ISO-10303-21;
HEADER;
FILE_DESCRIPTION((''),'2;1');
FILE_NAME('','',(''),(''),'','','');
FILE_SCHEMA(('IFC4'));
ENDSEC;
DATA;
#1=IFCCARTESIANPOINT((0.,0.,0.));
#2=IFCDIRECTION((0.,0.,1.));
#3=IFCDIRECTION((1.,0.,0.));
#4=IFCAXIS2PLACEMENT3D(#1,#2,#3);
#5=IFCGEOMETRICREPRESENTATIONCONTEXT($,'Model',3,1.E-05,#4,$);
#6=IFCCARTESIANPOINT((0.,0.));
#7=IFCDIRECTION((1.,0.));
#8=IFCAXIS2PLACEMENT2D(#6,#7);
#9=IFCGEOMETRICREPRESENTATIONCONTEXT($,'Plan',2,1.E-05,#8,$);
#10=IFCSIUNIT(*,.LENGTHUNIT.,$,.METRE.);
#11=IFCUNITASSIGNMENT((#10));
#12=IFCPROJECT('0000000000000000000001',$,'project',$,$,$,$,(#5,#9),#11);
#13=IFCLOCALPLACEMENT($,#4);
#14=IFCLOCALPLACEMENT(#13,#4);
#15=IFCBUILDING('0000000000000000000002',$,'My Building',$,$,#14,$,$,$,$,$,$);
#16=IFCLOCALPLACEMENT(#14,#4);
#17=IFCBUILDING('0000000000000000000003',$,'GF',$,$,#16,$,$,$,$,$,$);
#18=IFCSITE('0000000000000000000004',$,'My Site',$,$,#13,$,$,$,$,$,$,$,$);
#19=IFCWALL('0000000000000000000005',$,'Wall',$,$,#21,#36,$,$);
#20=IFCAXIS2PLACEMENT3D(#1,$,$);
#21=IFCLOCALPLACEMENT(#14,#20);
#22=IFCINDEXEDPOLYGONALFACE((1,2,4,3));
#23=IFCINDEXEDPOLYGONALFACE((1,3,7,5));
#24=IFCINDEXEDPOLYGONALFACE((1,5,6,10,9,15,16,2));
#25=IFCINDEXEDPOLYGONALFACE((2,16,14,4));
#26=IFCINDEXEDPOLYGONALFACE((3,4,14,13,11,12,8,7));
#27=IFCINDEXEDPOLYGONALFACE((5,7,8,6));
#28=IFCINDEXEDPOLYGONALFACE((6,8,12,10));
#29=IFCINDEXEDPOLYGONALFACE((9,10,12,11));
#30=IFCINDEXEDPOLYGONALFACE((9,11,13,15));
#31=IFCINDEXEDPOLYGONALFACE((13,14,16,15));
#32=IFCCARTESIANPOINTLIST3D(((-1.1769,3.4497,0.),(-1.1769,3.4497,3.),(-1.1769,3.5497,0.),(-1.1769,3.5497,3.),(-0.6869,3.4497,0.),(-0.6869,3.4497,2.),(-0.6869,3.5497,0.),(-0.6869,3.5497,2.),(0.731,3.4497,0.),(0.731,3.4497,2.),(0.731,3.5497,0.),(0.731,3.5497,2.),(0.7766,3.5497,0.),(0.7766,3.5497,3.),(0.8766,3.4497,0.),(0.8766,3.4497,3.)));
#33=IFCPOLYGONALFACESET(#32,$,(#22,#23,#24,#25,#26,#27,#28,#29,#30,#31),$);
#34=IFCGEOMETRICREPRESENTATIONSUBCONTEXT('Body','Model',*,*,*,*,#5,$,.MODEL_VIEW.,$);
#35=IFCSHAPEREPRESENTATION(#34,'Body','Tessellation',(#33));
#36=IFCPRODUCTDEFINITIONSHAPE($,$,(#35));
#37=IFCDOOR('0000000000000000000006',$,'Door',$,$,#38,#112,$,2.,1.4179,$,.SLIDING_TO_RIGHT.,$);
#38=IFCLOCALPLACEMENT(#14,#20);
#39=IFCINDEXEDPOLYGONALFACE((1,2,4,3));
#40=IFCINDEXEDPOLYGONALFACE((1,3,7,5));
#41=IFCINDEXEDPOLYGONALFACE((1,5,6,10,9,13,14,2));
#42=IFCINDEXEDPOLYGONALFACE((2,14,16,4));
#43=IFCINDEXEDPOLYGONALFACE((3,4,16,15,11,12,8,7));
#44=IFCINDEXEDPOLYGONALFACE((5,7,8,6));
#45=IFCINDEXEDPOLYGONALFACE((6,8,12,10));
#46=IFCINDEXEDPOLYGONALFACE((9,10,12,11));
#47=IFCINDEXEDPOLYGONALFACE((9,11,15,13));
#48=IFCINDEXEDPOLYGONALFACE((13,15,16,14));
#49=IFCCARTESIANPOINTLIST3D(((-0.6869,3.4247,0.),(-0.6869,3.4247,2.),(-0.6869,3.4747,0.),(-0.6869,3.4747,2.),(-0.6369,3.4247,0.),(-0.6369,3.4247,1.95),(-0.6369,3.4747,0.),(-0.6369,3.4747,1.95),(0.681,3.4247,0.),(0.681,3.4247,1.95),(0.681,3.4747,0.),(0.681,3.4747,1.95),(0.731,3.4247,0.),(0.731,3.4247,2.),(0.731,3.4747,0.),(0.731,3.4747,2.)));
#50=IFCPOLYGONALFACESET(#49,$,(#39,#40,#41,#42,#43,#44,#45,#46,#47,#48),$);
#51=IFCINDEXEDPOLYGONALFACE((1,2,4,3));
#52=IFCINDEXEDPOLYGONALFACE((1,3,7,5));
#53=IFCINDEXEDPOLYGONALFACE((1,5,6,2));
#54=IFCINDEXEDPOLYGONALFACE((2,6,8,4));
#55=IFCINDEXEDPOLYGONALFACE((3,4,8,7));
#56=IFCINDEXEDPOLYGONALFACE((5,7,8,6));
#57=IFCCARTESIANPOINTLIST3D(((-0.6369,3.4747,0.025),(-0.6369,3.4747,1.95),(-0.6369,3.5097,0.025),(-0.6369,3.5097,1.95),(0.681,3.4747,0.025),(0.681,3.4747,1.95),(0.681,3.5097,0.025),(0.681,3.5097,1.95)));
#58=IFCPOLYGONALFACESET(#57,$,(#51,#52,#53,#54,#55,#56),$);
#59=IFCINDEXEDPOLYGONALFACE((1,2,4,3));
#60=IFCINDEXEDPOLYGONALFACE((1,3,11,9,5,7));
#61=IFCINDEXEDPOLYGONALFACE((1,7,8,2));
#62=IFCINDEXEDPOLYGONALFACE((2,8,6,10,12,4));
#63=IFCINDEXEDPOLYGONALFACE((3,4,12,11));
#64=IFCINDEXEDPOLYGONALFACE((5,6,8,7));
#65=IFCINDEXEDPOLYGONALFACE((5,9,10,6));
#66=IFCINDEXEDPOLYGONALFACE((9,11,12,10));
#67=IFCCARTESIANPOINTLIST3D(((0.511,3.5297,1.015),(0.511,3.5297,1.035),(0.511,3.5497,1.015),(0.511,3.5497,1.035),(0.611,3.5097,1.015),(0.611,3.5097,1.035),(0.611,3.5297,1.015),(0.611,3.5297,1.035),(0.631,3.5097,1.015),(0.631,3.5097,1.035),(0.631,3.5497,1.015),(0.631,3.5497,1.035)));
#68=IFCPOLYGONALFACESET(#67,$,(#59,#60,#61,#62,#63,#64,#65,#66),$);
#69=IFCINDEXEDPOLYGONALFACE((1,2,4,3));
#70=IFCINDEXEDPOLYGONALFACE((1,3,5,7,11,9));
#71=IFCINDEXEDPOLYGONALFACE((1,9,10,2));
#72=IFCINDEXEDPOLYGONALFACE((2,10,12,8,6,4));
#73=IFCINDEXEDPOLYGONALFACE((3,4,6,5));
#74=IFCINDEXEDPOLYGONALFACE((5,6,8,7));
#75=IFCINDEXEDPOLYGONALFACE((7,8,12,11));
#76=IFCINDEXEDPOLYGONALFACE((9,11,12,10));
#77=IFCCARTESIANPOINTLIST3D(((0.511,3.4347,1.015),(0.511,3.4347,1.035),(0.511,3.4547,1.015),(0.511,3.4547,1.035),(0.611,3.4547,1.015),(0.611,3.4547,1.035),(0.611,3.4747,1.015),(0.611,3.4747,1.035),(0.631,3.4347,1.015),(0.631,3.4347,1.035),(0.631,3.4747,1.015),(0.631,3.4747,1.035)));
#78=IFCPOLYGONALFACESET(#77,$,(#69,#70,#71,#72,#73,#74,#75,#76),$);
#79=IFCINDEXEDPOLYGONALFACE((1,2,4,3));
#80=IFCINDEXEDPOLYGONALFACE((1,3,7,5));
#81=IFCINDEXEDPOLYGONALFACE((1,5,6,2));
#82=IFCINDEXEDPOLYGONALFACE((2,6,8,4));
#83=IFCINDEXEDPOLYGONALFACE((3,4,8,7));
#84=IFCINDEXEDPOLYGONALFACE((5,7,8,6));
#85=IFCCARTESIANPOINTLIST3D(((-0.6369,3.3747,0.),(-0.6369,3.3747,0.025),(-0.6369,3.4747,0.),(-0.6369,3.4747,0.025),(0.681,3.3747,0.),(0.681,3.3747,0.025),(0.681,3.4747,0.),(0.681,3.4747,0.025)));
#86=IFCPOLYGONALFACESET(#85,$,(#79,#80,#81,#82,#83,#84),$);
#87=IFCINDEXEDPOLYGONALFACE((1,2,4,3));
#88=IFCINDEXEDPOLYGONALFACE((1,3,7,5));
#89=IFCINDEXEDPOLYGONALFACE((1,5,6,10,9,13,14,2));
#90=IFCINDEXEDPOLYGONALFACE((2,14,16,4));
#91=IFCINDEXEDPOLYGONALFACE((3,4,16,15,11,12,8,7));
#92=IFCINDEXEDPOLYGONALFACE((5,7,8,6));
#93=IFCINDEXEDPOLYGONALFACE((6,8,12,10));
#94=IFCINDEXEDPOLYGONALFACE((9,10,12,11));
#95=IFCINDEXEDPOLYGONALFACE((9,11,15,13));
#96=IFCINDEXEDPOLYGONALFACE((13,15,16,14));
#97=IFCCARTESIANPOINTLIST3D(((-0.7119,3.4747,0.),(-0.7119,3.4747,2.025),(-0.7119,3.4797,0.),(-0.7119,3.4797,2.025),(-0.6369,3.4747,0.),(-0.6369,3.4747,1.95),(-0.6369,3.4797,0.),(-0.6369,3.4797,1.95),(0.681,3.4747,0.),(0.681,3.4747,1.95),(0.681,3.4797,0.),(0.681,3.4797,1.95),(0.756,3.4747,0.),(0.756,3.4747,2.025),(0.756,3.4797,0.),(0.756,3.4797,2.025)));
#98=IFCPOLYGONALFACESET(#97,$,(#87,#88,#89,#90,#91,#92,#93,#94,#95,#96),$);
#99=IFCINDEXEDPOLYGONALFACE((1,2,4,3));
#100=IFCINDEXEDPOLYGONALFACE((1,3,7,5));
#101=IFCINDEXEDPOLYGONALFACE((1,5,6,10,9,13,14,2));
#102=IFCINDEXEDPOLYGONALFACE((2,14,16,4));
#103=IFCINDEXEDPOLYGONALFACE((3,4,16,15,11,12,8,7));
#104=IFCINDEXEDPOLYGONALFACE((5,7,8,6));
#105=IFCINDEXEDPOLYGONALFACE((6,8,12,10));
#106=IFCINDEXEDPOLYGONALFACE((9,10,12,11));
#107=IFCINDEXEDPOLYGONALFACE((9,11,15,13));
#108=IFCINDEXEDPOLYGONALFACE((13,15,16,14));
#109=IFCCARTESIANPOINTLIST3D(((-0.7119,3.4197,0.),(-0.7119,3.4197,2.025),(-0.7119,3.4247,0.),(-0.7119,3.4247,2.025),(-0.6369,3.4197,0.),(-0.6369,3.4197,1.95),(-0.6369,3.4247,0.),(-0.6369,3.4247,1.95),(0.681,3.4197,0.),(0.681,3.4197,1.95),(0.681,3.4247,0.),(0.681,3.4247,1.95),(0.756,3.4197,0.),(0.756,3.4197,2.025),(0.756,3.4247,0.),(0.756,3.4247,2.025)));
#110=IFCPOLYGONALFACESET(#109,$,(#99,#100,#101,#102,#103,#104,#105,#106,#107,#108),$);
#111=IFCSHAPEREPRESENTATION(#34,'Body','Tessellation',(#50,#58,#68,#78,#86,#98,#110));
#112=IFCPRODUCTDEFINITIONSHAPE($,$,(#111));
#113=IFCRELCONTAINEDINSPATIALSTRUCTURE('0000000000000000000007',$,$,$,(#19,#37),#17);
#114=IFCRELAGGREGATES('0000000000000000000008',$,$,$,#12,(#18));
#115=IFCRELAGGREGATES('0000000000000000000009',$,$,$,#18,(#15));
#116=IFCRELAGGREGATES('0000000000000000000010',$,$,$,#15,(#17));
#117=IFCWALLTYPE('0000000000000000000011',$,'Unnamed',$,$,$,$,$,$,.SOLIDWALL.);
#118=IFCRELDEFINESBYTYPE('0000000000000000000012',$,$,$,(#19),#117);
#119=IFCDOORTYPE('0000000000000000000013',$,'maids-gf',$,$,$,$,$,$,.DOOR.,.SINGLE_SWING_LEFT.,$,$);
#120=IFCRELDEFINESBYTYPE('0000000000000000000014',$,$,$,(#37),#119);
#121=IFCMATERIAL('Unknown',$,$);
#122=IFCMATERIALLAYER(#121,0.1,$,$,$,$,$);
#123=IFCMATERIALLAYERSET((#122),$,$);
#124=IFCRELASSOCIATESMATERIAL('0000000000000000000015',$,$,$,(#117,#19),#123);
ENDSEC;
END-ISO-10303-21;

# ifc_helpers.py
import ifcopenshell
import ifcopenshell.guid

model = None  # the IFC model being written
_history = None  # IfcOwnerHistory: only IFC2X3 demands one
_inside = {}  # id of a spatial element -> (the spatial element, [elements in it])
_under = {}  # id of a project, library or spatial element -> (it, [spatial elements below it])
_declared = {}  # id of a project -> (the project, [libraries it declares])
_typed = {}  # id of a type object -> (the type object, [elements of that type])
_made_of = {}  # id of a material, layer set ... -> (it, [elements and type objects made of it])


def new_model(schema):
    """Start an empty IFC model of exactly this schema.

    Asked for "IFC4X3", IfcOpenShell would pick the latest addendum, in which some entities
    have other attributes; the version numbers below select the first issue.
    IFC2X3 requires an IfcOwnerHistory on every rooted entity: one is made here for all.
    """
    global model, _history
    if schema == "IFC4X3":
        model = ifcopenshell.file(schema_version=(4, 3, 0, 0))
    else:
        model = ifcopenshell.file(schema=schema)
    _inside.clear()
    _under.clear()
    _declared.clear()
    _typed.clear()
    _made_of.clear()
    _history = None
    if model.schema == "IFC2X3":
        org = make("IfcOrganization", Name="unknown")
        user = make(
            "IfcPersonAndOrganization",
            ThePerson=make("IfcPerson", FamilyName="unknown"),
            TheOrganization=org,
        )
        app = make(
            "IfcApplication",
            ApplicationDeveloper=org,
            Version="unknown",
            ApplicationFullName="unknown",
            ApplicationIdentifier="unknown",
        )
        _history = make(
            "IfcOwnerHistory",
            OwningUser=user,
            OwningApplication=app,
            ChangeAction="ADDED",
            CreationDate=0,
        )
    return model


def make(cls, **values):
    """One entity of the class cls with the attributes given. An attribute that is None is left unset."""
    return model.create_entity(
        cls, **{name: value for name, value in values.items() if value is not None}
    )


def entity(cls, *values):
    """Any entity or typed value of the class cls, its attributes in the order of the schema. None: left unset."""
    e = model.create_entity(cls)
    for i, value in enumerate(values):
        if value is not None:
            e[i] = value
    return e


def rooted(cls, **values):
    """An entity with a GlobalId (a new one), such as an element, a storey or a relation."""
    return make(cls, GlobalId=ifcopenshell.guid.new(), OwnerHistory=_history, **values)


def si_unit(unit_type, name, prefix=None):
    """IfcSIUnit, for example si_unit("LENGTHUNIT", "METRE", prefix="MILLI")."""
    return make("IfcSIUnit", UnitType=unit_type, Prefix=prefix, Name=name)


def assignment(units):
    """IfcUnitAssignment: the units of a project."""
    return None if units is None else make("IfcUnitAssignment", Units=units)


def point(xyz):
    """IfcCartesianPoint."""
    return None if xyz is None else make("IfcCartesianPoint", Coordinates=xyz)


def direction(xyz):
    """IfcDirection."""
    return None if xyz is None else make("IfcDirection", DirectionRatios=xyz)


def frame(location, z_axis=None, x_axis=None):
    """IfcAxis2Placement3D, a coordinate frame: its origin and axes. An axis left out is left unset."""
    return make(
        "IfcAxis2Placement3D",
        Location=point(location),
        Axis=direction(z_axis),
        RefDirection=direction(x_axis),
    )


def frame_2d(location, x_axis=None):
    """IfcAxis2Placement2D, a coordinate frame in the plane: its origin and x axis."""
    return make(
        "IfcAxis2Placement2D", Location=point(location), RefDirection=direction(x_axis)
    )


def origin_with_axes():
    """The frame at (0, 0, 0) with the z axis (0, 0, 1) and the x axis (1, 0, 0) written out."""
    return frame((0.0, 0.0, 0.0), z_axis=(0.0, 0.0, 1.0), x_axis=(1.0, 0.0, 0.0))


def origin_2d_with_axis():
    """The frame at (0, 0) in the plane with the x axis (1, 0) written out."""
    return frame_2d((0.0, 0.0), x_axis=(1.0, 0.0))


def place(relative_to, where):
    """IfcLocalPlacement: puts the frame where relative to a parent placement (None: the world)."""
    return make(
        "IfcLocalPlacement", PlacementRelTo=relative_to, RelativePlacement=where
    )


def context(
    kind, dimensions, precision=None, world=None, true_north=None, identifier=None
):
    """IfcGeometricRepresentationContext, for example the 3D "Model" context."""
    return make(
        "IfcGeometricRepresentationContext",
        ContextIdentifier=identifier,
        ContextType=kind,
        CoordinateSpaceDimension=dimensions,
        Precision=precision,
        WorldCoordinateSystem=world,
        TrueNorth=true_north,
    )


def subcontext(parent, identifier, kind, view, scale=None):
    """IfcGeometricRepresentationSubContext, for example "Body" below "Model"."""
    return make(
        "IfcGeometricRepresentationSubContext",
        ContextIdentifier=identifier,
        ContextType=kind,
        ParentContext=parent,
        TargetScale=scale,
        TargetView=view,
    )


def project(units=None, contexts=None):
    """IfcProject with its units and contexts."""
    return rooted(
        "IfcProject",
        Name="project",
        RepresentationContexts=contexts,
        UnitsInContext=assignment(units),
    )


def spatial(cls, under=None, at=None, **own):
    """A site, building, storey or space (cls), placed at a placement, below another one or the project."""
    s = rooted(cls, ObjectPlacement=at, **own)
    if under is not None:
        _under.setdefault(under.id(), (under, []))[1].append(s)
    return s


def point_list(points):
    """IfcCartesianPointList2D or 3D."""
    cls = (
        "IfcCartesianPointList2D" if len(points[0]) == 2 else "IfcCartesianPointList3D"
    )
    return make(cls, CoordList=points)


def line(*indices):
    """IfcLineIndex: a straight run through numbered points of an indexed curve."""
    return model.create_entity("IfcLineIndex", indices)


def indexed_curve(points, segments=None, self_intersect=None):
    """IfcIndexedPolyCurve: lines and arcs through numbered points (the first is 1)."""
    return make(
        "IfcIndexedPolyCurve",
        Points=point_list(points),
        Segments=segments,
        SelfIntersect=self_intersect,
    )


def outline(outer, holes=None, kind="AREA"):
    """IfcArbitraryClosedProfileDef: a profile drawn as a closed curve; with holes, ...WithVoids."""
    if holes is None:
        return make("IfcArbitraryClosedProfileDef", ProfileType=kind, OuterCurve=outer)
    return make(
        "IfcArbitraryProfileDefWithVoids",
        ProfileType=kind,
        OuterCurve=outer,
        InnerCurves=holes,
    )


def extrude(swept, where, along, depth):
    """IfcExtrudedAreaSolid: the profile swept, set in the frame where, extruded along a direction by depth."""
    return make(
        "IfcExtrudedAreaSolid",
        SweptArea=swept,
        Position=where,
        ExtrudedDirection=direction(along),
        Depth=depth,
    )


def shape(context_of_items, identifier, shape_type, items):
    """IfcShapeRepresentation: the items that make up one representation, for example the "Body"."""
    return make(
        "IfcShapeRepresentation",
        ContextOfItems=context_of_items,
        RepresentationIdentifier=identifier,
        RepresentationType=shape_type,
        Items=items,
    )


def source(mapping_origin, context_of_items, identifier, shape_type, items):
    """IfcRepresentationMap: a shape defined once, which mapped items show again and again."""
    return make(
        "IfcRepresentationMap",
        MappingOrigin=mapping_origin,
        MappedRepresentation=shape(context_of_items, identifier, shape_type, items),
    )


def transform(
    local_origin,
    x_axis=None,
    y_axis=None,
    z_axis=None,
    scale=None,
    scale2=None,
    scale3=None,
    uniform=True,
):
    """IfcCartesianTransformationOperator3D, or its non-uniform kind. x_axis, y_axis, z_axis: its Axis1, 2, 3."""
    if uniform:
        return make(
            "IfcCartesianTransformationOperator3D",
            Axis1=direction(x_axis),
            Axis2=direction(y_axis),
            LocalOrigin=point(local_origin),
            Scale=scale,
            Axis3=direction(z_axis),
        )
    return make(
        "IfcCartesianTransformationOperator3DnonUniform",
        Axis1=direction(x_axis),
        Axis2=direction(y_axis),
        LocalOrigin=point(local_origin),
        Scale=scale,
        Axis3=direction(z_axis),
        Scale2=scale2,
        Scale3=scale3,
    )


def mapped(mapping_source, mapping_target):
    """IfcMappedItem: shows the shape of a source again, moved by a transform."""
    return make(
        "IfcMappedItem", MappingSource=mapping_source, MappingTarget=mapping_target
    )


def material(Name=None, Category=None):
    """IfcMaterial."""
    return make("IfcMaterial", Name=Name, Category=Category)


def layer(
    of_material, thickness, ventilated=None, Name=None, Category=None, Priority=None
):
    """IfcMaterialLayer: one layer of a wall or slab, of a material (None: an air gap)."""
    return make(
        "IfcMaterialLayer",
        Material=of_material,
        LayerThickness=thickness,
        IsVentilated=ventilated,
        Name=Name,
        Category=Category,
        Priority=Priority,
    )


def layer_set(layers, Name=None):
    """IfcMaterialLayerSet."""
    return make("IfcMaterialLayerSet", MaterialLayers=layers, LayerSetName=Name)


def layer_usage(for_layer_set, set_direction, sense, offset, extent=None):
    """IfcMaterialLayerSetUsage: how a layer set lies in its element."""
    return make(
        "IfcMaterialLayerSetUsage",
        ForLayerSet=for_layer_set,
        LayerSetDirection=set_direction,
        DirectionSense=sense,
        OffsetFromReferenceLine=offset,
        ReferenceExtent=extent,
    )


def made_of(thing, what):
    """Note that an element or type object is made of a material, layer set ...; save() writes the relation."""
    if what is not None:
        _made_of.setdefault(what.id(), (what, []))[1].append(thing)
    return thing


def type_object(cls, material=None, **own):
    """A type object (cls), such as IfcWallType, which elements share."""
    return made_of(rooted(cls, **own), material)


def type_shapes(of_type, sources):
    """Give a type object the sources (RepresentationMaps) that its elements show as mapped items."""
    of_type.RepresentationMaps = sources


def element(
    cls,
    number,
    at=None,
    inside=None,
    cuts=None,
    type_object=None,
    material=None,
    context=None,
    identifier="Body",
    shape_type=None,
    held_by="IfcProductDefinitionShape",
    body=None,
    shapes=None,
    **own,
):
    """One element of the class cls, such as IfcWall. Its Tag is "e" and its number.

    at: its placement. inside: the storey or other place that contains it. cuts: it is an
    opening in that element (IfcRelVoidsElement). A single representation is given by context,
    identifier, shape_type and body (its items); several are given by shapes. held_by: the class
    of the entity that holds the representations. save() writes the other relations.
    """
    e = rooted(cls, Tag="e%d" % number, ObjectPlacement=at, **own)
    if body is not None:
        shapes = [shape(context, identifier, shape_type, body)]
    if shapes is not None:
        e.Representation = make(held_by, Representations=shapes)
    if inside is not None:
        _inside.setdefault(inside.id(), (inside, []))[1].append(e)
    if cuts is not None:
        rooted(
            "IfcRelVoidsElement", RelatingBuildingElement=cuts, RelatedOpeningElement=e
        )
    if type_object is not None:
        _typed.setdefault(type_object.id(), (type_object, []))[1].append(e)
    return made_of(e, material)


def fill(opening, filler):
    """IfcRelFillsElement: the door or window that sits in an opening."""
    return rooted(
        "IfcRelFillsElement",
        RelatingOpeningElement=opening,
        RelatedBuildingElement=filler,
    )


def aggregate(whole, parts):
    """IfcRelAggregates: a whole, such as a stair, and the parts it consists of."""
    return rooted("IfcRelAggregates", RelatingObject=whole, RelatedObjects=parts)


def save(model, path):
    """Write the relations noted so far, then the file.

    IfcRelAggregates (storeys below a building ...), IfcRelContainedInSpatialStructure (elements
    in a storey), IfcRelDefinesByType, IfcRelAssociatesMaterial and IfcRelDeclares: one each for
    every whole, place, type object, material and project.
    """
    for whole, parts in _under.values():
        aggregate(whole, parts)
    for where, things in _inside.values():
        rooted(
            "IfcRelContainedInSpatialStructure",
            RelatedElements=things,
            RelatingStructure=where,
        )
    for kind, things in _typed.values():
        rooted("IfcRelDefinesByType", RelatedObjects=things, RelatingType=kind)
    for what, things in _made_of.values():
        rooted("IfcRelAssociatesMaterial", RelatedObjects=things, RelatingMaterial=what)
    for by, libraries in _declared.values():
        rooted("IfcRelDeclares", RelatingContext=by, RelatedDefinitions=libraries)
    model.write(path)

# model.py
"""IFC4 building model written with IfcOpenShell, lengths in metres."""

from ifc_helpers import new_model, entity, si_unit, frame, origin_with_axes, origin_2d_with_axis, place, context, subcontext, project, spatial, line, indexed_curve, outline, extrude, shape, source, transform, mapped, material, layer, layer_set, layer_usage, type_object, type_shapes, element, fill, save


model = new_model("IFC4")

# Units and contexts
model_context = context("Model", 3, precision=1e-05, world=origin_with_axes())
plan_context = context("Plan", 2, precision=1e-05, world=origin_2d_with_axis())
body_context_1 = subcontext(model_context, "Body", "Model", "MODEL_VIEW")
body_context_2 = subcontext(plan_context, "Body", "Plan", "PLAN_VIEW")
ifc_project = project(units=[si_unit("LENGTHUNIT", "METRE")], contexts=[model_context, plan_context])

# Site, buildings
site_placement = place(None, origin_with_axes())
site = spatial("IfcSite", under=ifc_project, at=site_placement, Name="My Site")
building_1_placement = place(site_placement, origin_with_axes())
building_1 = spatial("IfcBuilding", under=site, at=building_1_placement, Name="My Building")
building_2_placement = place(building_1_placement, origin_with_axes())
building_2 = spatial("IfcBuilding", under=building_1, at=building_2_placement, Name="GF")

# Shared definitions
ifc_material = material(Name="Unknown")

# Shared definitions
ifc_layer_1 = layer(ifc_material, 0.1)
ifc_layer_set_1 = layer_set([ifc_layer_1])
wall_type = type_object("IfcWallType", Name="Unnamed", PredefinedType="SOLIDWALL", material=ifc_layer_set_1)

# Wall, opening, door
ifc_layer_usage_1 = layer_usage(ifc_layer_set_1, "AXIS2", "POSITIVE", 0.0)
wall_1_placement = place(building_2_placement, frame((0.8766, 3.5497, 0.0), z_axis=(0.0, 0.0, 1.0), x_axis=(-1.0, 0.0, 0.0)))
wall_1 = element("IfcWall", 1, at=wall_1_placement, inside=building_2, type_object=wall_type, material=ifc_layer_usage_1, Name="Wall", context=body_context_1, shape_type="SweptSolid", body=[
    extrude(outline(indexed_curve([(0.1, 0.0), (0.0, 0.1), (2.0535, 0.1), (2.0535, 0.0)], segments=[line(1, 2, 3, 4, 1)])), origin_with_axes(), (0.0, 0.0, 1.0), 3.0),
])
shared_shape_1 = source(origin_with_axes(), body_context_1, "Body", "SweptSolid", [
    extrude(outline(indexed_curve([(0.0, 0.0), (1.4179, 0.0), (1.4179, 2.0), (0.0, 2.0)], segments=[line(1, 2, 3, 4, 1)])), frame((0.0, -0.6, 0.0), z_axis=(0.0, -1.0, 0.0), x_axis=(1.0, 0.0, 0.0)), (0.0, 0.0, -1.0), 1.2),
])
opening_1_placement = place(wall_1_placement, frame((0.1456, 0.075, 0.0), z_axis=(0.0, 0.0, 1.0), x_axis=(1.0, -0.000001, 0.0)))
opening_1 = element("IfcOpeningElement", 2, at=opening_1_placement, cuts=wall_1, PredefinedType="OPENING", context=body_context_1, shape_type="MappedRepresentation", body=[
    mapped(shared_shape_1, transform((0.0, 0.0, 0.0), x_axis=(1.0, 0.0, 0.0), y_axis=(0.0, 1.0, 0.0), z_axis=(0.0, 0.0, 1.0), scale=1.0)),
])
door_type_1 = type_object("IfcDoorType", Name="maids-gf", OperationType="SINGLE_SWING_LEFT", PredefinedType="DOOR")
shared_shape_2 = source(origin_with_axes(), body_context_1, "Body", "SweptSolid", [
    extrude(outline(indexed_curve([(0.0, 0.0), (0.0, 2.0), (1.4179, 2.0), (1.4179, 0.0), (1.3679, 0.0), (1.3679, 1.95), (0.05, 1.95), (0.05, 0.0)], segments=[line(1, 2, 3, 4, 5, 6, 7, 8, 1)])), frame((0.0, 0.0, 0.0), z_axis=(0.0, -1.0, 0.0), x_axis=(1.0, 0.0, 0.0)), (0.0, 0.0, -1.0), 0.05),
    extrude(outline(indexed_curve([(0.0, 0.0), (1.3179, 0.0), (1.3179, 0.035), (0.0, 0.035)], segments=[line(1, 2, 3, 4, 1)])), frame((0.05, -0.035, 0.025), z_axis=(0.0, 0.0, 1.0), x_axis=(1.0, 0.0, 0.0)), (0.0, 0.0, 1.0), 1.925),
    extrude(outline(indexed_curve([(0.0, 0.0), (0.0, -0.04), (0.12, -0.04), (0.12, -0.02), (0.02, -0.02), (0.02, 0.0)], segments=[line(1, 2, 3, 4, 5, 6, 1)])), frame((0.1, -0.035, 1.015), z_axis=(0.0, 0.0, 1.0), x_axis=(1.0, 0.0, 0.0)), (0.0, 0.0, 1.0), 0.02),
    extrude(outline(indexed_curve([(0.0, 0.0), (0.0, 0.04), (0.12, 0.04), (0.12, 0.02), (0.02, 0.02), (0.02, 0.0)], segments=[line(1, 2, 3, 4, 5, 6, 1)])), frame((0.1, 0.0, 1.015), z_axis=(0.0, 0.0, 1.0), x_axis=(1.0, 0.0, 0.0)), (0.0, 0.0, 1.0), 0.02),
    extrude(outline(indexed_curve([(0.0, 0.0), (1.3179, 0.0), (1.3179, 0.1), (0.0, 0.1)], segments=[line(1, 2, 3, 4, 1)])), frame((0.05, 0.0, 0.0), z_axis=(0.0, 0.0, 1.0), x_axis=(1.0, 0.0, 0.0)), (0.0, 0.0, 1.0), 0.025),
    extrude(outline(indexed_curve([(0.0, 0.0), (0.0, 2.025), (1.4679, 2.025), (1.4679, 0.0), (1.3929, 0.0), (1.3929, 1.95), (0.075, 1.95), (0.075, 0.0)], segments=[line(1, 2, 3, 4, 5, 6, 7, 8, 1)])), frame((-0.025, -0.005, 0.0), z_axis=(0.0, -1.0, 0.0), x_axis=(1.0, 0.0, 0.0)), (0.0, 0.0, -1.0), 0.005),
    extrude(outline(indexed_curve([(0.0, 0.0), (0.0, 2.025), (1.4679, 2.025), (1.4679, 0.0), (1.3929, 0.0), (1.3929, 1.95), (0.075, 1.95), (0.075, 0.0)], segments=[line(1, 2, 3, 4, 5, 6, 7, 8, 1)])), frame((-0.025, 0.05, 0.0), z_axis=(0.0, -1.0, 0.0), x_axis=(1.0, 0.0, 0.0)), (0.0, 0.0, -1.0), 0.005),
])
shared_shape_3 = source(origin_with_axes(), body_context_2, "Body", "Curve2D", [
    entity("IfcIndexedPolyCurve", entity("IfcCartesianPointList2D", [[0.0, 0.0], [0.05, 0.0], [0.05, 0.05], [0.0, 0.05]]), [entity("IfcLineIndex", [1, 2, 3, 4, 1])]),
    entity("IfcIndexedPolyCurve", entity("IfcCartesianPointList2D", [[1.4179, 0.0], [1.3679, 0.0], [1.3679, 0.05], [1.4179, 0.05]]), [entity("IfcLineIndex", [1, 2, 3, 4, 1])]),
    entity("IfcIndexedPolyCurve", entity("IfcCartesianPointList2D", [[2.0269, -0.035], [0.709, -0.035], [0.709, 0.0], [2.0269, 0.0]]), [entity("IfcLineIndex", [1, 2, 3, 4, 1])]),
])
type_shapes(door_type_1, [shared_shape_2, shared_shape_3])
door_1_placement = place(opening_1_placement, frame((0.0, 0.0, 0.0), z_axis=(0.0, 0.0, 1.0), x_axis=(1.0, 0.0, 0.0)))
door_1 = element("IfcDoor", 3, at=door_1_placement, inside=building_2, type_object=door_type_1, Name="Door", OperationType="SLIDING_TO_RIGHT", OverallHeight=2.0, OverallWidth=1.4179, shapes=[
    shape(body_context_1, "Body", "MappedRepresentation", [mapped(shared_shape_2, transform((0.0, 0.0, 0.0), x_axis=(1.0, 0.0, 0.0), y_axis=(0.0, 1.0, 0.0), z_axis=(0.0, 0.0, 1.0), scale=1.0))]),
    shape(body_context_2, "Body", "MappedRepresentation", [mapped(shared_shape_3, transform((0.0, 0.0, 0.0), x_axis=(1.0, 0.0, 0.0), y_axis=(0.0, 1.0, 0.0), z_axis=(0.0, 0.0, 1.0), scale=1.0))]),
])
fill(opening_1, door_1)

save(model, "model.ifc")
